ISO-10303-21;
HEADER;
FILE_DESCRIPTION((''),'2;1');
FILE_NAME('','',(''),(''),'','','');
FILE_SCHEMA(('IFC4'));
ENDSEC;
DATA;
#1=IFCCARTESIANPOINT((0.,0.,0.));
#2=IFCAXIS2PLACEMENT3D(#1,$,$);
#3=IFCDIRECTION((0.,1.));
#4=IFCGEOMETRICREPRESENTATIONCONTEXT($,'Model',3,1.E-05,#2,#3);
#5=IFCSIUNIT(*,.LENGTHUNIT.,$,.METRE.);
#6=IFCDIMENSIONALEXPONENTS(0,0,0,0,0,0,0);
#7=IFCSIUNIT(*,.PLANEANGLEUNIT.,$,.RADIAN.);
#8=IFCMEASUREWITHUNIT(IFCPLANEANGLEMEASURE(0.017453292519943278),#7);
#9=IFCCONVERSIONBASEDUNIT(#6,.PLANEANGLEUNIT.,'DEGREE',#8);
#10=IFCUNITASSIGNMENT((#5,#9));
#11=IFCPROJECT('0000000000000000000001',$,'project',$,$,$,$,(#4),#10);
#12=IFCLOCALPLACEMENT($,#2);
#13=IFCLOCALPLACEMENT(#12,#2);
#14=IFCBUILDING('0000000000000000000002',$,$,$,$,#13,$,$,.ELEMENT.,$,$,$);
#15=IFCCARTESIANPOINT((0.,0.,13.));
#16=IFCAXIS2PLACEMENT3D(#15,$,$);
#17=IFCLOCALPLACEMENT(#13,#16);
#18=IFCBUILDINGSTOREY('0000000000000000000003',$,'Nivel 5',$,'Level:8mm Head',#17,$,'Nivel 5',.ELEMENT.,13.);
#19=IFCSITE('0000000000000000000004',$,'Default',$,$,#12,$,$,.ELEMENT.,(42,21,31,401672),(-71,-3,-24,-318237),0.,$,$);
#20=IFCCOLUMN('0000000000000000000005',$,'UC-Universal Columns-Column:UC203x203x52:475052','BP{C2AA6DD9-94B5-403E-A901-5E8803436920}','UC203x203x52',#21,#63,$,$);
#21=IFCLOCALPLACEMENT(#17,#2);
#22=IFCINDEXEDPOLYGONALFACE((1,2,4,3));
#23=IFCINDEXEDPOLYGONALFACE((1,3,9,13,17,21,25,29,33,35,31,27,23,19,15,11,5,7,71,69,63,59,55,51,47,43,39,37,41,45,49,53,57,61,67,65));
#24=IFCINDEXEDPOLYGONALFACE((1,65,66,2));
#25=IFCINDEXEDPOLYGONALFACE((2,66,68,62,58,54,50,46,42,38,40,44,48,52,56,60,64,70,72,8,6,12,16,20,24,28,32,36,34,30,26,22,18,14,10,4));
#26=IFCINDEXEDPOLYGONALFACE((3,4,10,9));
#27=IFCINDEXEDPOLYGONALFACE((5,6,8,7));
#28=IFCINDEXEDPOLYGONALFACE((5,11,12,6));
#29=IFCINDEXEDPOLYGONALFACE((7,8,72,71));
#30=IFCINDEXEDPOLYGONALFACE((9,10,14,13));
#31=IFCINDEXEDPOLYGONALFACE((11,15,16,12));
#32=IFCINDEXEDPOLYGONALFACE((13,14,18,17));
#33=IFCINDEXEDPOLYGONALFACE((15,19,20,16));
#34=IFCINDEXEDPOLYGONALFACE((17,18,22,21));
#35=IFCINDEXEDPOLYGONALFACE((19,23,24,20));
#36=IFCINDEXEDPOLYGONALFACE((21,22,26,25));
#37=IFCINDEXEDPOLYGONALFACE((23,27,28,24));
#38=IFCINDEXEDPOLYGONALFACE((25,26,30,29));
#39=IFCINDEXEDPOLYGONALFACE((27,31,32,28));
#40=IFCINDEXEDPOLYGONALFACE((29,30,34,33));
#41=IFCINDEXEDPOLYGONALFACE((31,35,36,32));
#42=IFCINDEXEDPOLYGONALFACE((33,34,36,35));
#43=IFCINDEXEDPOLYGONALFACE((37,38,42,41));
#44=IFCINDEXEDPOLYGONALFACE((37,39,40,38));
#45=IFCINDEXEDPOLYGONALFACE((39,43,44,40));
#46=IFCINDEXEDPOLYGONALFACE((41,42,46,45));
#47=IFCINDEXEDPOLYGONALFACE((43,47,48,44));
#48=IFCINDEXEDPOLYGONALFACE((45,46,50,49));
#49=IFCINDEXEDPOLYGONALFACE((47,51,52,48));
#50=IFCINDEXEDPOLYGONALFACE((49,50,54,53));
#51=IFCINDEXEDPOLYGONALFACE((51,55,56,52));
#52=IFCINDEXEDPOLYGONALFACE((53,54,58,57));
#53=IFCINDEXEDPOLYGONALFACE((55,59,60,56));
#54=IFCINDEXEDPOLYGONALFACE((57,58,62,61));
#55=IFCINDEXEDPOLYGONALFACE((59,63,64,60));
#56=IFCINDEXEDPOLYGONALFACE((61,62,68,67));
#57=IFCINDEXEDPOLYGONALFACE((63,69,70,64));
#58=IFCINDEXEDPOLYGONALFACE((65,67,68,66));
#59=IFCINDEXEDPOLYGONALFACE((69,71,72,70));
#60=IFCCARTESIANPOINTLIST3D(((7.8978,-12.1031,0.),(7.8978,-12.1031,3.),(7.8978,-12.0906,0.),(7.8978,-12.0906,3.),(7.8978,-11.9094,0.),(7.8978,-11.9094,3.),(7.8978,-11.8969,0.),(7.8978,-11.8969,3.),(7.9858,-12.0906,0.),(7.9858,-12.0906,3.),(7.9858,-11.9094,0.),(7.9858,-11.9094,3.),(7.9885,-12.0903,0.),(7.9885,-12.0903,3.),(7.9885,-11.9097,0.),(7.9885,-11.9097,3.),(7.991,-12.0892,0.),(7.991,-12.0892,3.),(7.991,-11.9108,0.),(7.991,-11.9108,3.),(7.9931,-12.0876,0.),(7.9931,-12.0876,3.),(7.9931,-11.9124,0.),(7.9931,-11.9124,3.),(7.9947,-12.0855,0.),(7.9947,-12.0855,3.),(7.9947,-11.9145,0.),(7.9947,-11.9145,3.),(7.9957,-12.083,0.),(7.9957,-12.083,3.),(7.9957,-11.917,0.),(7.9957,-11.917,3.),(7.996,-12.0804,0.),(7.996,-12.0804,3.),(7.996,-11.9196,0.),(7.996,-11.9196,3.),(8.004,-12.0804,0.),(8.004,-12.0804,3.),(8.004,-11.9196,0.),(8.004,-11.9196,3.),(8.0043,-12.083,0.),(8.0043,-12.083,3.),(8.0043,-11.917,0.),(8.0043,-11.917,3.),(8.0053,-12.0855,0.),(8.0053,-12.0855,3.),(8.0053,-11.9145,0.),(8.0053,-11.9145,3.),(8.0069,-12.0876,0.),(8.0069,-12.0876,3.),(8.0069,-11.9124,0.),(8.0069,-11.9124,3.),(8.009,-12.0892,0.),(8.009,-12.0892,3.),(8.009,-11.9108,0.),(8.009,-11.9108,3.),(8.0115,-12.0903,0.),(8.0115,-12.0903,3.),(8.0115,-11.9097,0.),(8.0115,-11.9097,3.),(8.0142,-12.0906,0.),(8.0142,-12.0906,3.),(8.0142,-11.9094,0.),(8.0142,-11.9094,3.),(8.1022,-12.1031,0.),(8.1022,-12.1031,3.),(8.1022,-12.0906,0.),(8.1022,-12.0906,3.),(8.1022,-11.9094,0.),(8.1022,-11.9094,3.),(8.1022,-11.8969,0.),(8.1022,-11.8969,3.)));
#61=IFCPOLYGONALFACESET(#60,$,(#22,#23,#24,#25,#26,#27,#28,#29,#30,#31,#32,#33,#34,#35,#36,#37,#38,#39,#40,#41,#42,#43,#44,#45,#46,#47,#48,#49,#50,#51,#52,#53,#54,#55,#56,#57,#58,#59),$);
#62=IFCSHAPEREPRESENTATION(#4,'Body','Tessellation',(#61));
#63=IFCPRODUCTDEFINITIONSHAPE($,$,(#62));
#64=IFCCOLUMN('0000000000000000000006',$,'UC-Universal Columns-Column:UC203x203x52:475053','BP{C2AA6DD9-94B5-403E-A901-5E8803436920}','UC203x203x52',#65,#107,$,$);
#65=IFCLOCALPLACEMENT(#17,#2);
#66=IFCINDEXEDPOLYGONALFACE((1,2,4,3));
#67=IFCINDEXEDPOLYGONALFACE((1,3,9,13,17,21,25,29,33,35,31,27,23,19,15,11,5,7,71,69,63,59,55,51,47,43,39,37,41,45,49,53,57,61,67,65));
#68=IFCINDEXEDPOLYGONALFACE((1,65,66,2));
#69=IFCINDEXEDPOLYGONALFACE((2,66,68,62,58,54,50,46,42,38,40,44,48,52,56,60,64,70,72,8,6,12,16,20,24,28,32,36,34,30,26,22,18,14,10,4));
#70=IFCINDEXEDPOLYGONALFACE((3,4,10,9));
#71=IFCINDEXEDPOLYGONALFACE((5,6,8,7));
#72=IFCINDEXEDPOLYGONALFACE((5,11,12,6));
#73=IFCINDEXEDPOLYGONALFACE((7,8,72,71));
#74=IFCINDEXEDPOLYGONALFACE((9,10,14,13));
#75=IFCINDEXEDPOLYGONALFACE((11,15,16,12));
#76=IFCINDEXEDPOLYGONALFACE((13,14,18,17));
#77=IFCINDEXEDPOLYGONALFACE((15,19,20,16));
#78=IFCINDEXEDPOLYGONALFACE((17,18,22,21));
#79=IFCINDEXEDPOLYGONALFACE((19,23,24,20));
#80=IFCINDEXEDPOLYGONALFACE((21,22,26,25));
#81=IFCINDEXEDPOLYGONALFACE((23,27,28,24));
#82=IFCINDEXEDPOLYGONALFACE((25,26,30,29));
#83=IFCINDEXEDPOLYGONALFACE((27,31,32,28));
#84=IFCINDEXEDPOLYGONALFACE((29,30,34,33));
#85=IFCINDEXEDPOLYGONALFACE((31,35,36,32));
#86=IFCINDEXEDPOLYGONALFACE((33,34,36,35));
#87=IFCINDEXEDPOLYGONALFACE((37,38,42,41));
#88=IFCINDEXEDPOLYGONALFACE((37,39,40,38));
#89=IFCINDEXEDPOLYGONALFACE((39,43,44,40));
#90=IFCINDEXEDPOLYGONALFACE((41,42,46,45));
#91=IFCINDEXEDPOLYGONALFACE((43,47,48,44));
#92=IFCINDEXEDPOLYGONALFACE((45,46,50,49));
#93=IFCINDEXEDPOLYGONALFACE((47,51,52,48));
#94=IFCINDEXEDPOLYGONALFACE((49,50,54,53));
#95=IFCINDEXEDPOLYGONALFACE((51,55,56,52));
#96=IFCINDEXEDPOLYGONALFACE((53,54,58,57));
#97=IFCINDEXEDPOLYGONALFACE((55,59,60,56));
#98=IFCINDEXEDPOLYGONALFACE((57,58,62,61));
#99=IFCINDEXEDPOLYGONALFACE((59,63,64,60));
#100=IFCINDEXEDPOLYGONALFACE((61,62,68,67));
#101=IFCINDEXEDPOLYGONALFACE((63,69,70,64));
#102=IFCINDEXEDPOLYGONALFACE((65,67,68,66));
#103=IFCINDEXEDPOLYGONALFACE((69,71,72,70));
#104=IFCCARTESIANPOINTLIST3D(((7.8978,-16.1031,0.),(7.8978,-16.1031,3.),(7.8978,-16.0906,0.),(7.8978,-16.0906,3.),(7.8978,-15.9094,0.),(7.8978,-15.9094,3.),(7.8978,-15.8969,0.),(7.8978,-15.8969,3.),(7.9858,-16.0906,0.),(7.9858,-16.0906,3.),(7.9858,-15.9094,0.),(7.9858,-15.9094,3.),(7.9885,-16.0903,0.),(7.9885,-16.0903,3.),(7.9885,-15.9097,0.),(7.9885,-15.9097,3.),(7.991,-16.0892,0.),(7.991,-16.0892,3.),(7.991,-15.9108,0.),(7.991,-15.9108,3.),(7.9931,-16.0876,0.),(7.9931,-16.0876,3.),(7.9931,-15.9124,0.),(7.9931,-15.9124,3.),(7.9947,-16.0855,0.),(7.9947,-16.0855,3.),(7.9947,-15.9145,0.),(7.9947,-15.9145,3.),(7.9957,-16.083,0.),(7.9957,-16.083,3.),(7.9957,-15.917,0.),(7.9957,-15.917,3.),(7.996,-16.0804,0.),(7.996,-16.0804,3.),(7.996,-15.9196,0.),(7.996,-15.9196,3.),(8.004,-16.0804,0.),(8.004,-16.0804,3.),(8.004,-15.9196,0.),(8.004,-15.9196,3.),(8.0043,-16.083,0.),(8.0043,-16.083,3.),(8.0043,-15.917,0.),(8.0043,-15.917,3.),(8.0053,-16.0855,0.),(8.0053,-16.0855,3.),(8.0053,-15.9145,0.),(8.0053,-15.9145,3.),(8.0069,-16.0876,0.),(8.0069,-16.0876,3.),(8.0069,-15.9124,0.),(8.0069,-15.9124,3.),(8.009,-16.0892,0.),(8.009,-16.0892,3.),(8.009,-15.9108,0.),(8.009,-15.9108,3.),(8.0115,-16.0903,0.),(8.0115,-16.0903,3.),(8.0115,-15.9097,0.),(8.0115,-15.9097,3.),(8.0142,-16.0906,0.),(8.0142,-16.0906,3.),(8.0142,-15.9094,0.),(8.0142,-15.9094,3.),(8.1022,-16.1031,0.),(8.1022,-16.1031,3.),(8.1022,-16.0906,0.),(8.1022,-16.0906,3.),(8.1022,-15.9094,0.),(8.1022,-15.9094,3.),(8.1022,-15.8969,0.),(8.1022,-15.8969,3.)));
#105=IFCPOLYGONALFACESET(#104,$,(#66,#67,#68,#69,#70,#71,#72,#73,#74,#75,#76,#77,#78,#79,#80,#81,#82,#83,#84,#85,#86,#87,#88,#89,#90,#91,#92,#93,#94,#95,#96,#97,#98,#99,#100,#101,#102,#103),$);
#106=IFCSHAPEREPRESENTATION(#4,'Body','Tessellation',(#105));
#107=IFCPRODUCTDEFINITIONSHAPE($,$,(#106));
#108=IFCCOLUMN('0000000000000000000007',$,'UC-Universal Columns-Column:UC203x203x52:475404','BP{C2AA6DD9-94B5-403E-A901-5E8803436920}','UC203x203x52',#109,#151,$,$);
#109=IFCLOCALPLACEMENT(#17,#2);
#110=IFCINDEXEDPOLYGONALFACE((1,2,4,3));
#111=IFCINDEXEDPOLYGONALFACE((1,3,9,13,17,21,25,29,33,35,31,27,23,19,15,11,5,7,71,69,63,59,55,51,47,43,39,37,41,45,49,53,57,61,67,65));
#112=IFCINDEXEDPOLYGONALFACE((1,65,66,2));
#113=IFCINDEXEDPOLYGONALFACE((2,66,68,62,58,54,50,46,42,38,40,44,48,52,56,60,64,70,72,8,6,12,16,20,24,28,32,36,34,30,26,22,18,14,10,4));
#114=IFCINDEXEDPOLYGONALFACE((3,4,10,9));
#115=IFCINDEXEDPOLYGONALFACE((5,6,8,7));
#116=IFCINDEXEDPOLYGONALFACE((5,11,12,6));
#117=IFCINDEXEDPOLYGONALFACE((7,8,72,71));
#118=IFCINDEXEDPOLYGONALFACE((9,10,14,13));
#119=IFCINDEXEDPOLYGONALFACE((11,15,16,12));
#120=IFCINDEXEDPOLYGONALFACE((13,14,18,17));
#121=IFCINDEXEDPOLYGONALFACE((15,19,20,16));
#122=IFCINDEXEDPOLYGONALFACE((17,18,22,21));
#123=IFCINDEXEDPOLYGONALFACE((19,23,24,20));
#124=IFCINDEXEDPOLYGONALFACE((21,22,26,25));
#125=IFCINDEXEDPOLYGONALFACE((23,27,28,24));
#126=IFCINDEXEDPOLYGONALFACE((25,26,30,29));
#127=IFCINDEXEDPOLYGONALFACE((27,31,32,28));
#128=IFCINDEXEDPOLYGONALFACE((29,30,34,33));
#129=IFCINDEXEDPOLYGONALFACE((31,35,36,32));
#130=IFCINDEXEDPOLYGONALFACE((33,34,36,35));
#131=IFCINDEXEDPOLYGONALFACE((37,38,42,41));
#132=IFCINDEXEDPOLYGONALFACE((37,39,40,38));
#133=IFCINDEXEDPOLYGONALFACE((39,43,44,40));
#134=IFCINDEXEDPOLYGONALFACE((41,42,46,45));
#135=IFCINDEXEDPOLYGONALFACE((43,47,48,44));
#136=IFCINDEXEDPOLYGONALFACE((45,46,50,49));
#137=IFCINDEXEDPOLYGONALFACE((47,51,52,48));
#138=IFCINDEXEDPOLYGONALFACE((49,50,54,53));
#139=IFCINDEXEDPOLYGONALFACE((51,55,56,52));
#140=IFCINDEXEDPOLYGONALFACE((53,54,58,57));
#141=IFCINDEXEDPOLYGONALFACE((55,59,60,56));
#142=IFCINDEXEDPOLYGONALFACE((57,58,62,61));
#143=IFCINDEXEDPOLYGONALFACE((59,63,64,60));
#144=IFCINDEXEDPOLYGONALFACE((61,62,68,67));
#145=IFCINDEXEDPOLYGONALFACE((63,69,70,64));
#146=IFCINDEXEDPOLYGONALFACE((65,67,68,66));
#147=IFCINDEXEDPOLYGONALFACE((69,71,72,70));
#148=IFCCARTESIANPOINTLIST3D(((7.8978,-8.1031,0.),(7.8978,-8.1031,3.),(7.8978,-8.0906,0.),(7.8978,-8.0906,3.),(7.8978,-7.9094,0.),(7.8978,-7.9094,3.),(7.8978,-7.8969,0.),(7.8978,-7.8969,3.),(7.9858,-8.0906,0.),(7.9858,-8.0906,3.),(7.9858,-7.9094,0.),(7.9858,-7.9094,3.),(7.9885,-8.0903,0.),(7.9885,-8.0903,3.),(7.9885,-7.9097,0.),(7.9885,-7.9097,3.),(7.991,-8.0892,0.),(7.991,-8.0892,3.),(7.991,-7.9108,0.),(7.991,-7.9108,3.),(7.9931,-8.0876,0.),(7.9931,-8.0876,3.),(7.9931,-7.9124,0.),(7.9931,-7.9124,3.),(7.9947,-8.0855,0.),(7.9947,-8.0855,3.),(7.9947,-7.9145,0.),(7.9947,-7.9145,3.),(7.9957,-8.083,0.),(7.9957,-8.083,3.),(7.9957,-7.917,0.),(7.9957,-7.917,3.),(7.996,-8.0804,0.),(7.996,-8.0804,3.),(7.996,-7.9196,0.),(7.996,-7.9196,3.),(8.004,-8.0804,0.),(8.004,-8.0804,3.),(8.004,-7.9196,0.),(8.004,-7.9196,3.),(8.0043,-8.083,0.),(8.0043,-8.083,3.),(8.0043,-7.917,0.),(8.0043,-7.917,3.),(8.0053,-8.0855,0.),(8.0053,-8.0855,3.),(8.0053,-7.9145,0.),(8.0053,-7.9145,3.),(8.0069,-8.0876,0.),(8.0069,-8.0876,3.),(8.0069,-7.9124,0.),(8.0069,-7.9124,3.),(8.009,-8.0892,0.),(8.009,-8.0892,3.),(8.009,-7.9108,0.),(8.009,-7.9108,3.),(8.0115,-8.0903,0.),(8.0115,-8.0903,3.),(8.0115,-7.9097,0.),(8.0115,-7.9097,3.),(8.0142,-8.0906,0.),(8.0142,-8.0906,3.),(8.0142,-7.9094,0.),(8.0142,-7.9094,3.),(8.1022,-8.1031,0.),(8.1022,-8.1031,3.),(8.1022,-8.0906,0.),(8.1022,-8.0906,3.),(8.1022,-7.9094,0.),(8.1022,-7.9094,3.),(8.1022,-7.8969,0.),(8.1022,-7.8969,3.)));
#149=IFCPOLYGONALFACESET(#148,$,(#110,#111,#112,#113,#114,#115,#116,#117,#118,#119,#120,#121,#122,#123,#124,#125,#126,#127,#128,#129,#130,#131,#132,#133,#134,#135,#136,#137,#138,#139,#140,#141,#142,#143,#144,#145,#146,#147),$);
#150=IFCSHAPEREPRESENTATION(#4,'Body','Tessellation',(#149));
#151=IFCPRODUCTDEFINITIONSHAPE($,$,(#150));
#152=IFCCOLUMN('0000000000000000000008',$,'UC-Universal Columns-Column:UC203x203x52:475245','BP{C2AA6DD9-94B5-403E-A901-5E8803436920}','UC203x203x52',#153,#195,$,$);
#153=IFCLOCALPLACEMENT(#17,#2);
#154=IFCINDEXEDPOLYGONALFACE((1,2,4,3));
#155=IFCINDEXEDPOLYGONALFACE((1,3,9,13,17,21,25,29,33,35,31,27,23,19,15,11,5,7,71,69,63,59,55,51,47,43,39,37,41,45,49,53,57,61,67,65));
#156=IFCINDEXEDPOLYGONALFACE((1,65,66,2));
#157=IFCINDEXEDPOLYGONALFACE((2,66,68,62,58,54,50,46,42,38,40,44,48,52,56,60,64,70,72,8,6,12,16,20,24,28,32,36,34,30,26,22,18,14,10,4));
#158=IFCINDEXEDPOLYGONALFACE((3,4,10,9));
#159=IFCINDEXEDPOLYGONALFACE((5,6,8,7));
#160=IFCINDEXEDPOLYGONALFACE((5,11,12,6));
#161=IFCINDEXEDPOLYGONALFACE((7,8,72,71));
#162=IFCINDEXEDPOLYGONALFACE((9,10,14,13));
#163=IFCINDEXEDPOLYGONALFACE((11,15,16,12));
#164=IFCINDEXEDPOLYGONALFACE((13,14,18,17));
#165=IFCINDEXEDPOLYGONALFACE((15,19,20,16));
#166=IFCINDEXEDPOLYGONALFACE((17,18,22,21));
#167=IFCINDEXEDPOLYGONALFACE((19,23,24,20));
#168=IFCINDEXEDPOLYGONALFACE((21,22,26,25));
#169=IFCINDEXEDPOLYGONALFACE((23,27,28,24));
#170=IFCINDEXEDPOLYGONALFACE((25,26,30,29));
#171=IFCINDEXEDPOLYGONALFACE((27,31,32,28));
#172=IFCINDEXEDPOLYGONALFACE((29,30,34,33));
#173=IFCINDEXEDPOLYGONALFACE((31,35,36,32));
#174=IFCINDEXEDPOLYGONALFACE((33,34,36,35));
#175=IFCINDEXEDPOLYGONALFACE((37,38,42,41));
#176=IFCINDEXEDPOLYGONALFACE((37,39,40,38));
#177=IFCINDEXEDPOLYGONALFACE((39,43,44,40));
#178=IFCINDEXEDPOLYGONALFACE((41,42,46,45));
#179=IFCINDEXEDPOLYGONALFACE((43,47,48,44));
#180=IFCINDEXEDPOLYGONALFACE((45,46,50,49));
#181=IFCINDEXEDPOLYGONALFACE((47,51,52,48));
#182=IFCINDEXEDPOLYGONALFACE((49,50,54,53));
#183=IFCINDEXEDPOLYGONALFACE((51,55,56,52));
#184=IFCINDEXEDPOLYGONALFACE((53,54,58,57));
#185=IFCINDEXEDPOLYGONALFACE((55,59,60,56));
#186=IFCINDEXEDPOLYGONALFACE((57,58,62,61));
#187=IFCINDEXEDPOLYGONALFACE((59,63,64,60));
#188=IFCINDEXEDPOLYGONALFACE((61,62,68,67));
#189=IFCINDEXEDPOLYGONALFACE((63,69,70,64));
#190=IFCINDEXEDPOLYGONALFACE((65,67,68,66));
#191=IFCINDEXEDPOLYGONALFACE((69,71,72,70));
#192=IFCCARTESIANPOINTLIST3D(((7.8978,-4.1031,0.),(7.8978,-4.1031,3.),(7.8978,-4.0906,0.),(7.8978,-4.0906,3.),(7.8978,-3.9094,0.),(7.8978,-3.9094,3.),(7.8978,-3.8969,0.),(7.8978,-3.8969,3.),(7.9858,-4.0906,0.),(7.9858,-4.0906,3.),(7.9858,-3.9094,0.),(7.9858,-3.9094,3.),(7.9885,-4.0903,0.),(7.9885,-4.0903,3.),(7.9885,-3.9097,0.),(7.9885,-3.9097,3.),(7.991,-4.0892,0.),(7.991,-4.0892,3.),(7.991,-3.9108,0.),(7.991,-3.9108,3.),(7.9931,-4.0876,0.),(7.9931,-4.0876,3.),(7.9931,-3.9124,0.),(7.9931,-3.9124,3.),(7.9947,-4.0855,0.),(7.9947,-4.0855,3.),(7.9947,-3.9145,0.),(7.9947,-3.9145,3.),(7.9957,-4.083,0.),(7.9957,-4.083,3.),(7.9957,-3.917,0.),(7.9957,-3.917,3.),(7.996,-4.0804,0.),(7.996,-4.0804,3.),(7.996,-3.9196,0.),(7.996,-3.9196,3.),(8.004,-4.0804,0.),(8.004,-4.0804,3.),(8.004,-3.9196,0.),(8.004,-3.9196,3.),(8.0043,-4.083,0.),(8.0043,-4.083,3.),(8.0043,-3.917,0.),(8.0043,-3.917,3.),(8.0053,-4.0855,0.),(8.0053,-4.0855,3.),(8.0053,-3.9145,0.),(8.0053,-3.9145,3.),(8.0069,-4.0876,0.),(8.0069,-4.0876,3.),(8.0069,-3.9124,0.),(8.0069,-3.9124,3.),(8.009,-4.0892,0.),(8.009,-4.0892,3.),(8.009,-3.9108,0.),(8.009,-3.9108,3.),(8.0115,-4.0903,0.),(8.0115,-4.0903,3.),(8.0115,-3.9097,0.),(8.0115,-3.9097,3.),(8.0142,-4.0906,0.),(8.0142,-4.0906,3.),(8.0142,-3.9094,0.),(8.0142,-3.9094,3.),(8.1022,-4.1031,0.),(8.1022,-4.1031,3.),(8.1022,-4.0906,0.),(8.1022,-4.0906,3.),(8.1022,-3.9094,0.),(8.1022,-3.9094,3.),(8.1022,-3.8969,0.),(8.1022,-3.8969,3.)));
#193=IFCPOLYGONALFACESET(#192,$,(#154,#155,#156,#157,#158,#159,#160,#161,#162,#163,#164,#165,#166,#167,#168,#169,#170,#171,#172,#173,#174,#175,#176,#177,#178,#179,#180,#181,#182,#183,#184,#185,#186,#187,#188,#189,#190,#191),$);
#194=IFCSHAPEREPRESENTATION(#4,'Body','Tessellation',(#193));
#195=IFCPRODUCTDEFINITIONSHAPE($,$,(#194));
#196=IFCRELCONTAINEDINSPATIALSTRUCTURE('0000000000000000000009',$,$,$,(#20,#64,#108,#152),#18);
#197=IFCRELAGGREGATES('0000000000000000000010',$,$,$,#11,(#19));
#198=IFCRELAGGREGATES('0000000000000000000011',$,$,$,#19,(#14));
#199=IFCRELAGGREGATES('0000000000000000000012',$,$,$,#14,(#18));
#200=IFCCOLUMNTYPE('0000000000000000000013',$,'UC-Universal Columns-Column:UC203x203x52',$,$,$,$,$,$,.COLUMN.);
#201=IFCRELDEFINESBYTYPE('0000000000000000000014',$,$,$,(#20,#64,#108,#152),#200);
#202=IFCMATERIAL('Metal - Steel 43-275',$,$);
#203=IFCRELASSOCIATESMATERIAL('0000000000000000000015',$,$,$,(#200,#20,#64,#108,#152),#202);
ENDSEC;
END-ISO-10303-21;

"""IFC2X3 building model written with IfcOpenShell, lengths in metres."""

from ifc_helpers import new_model, entity, si_unit, converted_unit, direction, frame, origin, origin_2d, place, context, project, spatial, i_section, extrude, material, type_object, element, save


model = new_model("IFC2X3")

# Units and contexts
model_context = context("Model", 3, precision=1e-05, world=origin(), true_north=direction((0.0, 1.0)))
ifc_project = project(units=[si_unit("LENGTHUNIT", "METRE"), converted_unit("PLANEANGLEUNIT", "DEGREE", entity("IfcPlaneAngleMeasure", 0.017453292519943278), si_unit("PLANEANGLEUNIT", "RADIAN"), dimensions=[0, 0, 0, 0, 0, 0, 0])], contexts=[model_context])

# Site, building, storey
site_placement = place(None, origin())
site = spatial("IfcSite", under=ifc_project, at=site_placement, Name="Default", CompositionType="ELEMENT", RefLatitude=(42, 21, 31, 401672), RefLongitude=(-71, -3, -24, -318237), RefElevation=0.0)
building_placement = place(site_placement, origin())
building = spatial("IfcBuilding", under=site, at=building_placement, CompositionType="ELEMENT")
storey_placement = place(building_placement, frame((0.0, 0.0, 13.0)))
storey = spatial("IfcBuildingStorey", under=building, at=storey_placement, Name="Nivel 5", ObjectType="Level:8mm Head", LongName="Nivel 5", CompositionType="ELEMENT", Elevation=13.0)

# Columns
ifc_material_1 = material(Name="Metal - Steel 43-275")
column_type_1 = type_object("IfcColumnType", Name="UC-Universal Columns-Column:UC203x203x52", PredefinedType="COLUMN", material=ifc_material_1)
for number, where, name in (
    (1, (8.0, -12.0, 3.0), "UC-Universal Columns-Column:UC203x203x52:475052"),
    (2, (8.0, -16.0, 3.0), "UC-Universal Columns-Column:UC203x203x52:475053"),
    (3, (8.0, -8.0, 3.0), "UC-Universal Columns-Column:UC203x203x52:475404"),
    (4, (8.0, -4.0, 3.0), "UC-Universal Columns-Column:UC203x203x52:475245"),
):
    element("IfcColumn", number, at=place(storey_placement, frame(where)), inside=storey, type_object=column_type_1, material=ifc_material_1, Name=name, Description="BP{C2AA6DD9-94B5-403E-A901-5E8803436920}", ObjectType="UC203x203x52", context=model_context, shape_type="SweptSolid", body=[
        extrude(i_section(OverallWidth=0.2043, OverallDepth=0.2062, WebThickness=0.0079, FlangeThickness=0.0125, FilletRadius=0.0102, at=origin_2d()), origin(), (0.0, 0.0, -1.0), 3.0),
    ])

save(model, "model.ifc")
